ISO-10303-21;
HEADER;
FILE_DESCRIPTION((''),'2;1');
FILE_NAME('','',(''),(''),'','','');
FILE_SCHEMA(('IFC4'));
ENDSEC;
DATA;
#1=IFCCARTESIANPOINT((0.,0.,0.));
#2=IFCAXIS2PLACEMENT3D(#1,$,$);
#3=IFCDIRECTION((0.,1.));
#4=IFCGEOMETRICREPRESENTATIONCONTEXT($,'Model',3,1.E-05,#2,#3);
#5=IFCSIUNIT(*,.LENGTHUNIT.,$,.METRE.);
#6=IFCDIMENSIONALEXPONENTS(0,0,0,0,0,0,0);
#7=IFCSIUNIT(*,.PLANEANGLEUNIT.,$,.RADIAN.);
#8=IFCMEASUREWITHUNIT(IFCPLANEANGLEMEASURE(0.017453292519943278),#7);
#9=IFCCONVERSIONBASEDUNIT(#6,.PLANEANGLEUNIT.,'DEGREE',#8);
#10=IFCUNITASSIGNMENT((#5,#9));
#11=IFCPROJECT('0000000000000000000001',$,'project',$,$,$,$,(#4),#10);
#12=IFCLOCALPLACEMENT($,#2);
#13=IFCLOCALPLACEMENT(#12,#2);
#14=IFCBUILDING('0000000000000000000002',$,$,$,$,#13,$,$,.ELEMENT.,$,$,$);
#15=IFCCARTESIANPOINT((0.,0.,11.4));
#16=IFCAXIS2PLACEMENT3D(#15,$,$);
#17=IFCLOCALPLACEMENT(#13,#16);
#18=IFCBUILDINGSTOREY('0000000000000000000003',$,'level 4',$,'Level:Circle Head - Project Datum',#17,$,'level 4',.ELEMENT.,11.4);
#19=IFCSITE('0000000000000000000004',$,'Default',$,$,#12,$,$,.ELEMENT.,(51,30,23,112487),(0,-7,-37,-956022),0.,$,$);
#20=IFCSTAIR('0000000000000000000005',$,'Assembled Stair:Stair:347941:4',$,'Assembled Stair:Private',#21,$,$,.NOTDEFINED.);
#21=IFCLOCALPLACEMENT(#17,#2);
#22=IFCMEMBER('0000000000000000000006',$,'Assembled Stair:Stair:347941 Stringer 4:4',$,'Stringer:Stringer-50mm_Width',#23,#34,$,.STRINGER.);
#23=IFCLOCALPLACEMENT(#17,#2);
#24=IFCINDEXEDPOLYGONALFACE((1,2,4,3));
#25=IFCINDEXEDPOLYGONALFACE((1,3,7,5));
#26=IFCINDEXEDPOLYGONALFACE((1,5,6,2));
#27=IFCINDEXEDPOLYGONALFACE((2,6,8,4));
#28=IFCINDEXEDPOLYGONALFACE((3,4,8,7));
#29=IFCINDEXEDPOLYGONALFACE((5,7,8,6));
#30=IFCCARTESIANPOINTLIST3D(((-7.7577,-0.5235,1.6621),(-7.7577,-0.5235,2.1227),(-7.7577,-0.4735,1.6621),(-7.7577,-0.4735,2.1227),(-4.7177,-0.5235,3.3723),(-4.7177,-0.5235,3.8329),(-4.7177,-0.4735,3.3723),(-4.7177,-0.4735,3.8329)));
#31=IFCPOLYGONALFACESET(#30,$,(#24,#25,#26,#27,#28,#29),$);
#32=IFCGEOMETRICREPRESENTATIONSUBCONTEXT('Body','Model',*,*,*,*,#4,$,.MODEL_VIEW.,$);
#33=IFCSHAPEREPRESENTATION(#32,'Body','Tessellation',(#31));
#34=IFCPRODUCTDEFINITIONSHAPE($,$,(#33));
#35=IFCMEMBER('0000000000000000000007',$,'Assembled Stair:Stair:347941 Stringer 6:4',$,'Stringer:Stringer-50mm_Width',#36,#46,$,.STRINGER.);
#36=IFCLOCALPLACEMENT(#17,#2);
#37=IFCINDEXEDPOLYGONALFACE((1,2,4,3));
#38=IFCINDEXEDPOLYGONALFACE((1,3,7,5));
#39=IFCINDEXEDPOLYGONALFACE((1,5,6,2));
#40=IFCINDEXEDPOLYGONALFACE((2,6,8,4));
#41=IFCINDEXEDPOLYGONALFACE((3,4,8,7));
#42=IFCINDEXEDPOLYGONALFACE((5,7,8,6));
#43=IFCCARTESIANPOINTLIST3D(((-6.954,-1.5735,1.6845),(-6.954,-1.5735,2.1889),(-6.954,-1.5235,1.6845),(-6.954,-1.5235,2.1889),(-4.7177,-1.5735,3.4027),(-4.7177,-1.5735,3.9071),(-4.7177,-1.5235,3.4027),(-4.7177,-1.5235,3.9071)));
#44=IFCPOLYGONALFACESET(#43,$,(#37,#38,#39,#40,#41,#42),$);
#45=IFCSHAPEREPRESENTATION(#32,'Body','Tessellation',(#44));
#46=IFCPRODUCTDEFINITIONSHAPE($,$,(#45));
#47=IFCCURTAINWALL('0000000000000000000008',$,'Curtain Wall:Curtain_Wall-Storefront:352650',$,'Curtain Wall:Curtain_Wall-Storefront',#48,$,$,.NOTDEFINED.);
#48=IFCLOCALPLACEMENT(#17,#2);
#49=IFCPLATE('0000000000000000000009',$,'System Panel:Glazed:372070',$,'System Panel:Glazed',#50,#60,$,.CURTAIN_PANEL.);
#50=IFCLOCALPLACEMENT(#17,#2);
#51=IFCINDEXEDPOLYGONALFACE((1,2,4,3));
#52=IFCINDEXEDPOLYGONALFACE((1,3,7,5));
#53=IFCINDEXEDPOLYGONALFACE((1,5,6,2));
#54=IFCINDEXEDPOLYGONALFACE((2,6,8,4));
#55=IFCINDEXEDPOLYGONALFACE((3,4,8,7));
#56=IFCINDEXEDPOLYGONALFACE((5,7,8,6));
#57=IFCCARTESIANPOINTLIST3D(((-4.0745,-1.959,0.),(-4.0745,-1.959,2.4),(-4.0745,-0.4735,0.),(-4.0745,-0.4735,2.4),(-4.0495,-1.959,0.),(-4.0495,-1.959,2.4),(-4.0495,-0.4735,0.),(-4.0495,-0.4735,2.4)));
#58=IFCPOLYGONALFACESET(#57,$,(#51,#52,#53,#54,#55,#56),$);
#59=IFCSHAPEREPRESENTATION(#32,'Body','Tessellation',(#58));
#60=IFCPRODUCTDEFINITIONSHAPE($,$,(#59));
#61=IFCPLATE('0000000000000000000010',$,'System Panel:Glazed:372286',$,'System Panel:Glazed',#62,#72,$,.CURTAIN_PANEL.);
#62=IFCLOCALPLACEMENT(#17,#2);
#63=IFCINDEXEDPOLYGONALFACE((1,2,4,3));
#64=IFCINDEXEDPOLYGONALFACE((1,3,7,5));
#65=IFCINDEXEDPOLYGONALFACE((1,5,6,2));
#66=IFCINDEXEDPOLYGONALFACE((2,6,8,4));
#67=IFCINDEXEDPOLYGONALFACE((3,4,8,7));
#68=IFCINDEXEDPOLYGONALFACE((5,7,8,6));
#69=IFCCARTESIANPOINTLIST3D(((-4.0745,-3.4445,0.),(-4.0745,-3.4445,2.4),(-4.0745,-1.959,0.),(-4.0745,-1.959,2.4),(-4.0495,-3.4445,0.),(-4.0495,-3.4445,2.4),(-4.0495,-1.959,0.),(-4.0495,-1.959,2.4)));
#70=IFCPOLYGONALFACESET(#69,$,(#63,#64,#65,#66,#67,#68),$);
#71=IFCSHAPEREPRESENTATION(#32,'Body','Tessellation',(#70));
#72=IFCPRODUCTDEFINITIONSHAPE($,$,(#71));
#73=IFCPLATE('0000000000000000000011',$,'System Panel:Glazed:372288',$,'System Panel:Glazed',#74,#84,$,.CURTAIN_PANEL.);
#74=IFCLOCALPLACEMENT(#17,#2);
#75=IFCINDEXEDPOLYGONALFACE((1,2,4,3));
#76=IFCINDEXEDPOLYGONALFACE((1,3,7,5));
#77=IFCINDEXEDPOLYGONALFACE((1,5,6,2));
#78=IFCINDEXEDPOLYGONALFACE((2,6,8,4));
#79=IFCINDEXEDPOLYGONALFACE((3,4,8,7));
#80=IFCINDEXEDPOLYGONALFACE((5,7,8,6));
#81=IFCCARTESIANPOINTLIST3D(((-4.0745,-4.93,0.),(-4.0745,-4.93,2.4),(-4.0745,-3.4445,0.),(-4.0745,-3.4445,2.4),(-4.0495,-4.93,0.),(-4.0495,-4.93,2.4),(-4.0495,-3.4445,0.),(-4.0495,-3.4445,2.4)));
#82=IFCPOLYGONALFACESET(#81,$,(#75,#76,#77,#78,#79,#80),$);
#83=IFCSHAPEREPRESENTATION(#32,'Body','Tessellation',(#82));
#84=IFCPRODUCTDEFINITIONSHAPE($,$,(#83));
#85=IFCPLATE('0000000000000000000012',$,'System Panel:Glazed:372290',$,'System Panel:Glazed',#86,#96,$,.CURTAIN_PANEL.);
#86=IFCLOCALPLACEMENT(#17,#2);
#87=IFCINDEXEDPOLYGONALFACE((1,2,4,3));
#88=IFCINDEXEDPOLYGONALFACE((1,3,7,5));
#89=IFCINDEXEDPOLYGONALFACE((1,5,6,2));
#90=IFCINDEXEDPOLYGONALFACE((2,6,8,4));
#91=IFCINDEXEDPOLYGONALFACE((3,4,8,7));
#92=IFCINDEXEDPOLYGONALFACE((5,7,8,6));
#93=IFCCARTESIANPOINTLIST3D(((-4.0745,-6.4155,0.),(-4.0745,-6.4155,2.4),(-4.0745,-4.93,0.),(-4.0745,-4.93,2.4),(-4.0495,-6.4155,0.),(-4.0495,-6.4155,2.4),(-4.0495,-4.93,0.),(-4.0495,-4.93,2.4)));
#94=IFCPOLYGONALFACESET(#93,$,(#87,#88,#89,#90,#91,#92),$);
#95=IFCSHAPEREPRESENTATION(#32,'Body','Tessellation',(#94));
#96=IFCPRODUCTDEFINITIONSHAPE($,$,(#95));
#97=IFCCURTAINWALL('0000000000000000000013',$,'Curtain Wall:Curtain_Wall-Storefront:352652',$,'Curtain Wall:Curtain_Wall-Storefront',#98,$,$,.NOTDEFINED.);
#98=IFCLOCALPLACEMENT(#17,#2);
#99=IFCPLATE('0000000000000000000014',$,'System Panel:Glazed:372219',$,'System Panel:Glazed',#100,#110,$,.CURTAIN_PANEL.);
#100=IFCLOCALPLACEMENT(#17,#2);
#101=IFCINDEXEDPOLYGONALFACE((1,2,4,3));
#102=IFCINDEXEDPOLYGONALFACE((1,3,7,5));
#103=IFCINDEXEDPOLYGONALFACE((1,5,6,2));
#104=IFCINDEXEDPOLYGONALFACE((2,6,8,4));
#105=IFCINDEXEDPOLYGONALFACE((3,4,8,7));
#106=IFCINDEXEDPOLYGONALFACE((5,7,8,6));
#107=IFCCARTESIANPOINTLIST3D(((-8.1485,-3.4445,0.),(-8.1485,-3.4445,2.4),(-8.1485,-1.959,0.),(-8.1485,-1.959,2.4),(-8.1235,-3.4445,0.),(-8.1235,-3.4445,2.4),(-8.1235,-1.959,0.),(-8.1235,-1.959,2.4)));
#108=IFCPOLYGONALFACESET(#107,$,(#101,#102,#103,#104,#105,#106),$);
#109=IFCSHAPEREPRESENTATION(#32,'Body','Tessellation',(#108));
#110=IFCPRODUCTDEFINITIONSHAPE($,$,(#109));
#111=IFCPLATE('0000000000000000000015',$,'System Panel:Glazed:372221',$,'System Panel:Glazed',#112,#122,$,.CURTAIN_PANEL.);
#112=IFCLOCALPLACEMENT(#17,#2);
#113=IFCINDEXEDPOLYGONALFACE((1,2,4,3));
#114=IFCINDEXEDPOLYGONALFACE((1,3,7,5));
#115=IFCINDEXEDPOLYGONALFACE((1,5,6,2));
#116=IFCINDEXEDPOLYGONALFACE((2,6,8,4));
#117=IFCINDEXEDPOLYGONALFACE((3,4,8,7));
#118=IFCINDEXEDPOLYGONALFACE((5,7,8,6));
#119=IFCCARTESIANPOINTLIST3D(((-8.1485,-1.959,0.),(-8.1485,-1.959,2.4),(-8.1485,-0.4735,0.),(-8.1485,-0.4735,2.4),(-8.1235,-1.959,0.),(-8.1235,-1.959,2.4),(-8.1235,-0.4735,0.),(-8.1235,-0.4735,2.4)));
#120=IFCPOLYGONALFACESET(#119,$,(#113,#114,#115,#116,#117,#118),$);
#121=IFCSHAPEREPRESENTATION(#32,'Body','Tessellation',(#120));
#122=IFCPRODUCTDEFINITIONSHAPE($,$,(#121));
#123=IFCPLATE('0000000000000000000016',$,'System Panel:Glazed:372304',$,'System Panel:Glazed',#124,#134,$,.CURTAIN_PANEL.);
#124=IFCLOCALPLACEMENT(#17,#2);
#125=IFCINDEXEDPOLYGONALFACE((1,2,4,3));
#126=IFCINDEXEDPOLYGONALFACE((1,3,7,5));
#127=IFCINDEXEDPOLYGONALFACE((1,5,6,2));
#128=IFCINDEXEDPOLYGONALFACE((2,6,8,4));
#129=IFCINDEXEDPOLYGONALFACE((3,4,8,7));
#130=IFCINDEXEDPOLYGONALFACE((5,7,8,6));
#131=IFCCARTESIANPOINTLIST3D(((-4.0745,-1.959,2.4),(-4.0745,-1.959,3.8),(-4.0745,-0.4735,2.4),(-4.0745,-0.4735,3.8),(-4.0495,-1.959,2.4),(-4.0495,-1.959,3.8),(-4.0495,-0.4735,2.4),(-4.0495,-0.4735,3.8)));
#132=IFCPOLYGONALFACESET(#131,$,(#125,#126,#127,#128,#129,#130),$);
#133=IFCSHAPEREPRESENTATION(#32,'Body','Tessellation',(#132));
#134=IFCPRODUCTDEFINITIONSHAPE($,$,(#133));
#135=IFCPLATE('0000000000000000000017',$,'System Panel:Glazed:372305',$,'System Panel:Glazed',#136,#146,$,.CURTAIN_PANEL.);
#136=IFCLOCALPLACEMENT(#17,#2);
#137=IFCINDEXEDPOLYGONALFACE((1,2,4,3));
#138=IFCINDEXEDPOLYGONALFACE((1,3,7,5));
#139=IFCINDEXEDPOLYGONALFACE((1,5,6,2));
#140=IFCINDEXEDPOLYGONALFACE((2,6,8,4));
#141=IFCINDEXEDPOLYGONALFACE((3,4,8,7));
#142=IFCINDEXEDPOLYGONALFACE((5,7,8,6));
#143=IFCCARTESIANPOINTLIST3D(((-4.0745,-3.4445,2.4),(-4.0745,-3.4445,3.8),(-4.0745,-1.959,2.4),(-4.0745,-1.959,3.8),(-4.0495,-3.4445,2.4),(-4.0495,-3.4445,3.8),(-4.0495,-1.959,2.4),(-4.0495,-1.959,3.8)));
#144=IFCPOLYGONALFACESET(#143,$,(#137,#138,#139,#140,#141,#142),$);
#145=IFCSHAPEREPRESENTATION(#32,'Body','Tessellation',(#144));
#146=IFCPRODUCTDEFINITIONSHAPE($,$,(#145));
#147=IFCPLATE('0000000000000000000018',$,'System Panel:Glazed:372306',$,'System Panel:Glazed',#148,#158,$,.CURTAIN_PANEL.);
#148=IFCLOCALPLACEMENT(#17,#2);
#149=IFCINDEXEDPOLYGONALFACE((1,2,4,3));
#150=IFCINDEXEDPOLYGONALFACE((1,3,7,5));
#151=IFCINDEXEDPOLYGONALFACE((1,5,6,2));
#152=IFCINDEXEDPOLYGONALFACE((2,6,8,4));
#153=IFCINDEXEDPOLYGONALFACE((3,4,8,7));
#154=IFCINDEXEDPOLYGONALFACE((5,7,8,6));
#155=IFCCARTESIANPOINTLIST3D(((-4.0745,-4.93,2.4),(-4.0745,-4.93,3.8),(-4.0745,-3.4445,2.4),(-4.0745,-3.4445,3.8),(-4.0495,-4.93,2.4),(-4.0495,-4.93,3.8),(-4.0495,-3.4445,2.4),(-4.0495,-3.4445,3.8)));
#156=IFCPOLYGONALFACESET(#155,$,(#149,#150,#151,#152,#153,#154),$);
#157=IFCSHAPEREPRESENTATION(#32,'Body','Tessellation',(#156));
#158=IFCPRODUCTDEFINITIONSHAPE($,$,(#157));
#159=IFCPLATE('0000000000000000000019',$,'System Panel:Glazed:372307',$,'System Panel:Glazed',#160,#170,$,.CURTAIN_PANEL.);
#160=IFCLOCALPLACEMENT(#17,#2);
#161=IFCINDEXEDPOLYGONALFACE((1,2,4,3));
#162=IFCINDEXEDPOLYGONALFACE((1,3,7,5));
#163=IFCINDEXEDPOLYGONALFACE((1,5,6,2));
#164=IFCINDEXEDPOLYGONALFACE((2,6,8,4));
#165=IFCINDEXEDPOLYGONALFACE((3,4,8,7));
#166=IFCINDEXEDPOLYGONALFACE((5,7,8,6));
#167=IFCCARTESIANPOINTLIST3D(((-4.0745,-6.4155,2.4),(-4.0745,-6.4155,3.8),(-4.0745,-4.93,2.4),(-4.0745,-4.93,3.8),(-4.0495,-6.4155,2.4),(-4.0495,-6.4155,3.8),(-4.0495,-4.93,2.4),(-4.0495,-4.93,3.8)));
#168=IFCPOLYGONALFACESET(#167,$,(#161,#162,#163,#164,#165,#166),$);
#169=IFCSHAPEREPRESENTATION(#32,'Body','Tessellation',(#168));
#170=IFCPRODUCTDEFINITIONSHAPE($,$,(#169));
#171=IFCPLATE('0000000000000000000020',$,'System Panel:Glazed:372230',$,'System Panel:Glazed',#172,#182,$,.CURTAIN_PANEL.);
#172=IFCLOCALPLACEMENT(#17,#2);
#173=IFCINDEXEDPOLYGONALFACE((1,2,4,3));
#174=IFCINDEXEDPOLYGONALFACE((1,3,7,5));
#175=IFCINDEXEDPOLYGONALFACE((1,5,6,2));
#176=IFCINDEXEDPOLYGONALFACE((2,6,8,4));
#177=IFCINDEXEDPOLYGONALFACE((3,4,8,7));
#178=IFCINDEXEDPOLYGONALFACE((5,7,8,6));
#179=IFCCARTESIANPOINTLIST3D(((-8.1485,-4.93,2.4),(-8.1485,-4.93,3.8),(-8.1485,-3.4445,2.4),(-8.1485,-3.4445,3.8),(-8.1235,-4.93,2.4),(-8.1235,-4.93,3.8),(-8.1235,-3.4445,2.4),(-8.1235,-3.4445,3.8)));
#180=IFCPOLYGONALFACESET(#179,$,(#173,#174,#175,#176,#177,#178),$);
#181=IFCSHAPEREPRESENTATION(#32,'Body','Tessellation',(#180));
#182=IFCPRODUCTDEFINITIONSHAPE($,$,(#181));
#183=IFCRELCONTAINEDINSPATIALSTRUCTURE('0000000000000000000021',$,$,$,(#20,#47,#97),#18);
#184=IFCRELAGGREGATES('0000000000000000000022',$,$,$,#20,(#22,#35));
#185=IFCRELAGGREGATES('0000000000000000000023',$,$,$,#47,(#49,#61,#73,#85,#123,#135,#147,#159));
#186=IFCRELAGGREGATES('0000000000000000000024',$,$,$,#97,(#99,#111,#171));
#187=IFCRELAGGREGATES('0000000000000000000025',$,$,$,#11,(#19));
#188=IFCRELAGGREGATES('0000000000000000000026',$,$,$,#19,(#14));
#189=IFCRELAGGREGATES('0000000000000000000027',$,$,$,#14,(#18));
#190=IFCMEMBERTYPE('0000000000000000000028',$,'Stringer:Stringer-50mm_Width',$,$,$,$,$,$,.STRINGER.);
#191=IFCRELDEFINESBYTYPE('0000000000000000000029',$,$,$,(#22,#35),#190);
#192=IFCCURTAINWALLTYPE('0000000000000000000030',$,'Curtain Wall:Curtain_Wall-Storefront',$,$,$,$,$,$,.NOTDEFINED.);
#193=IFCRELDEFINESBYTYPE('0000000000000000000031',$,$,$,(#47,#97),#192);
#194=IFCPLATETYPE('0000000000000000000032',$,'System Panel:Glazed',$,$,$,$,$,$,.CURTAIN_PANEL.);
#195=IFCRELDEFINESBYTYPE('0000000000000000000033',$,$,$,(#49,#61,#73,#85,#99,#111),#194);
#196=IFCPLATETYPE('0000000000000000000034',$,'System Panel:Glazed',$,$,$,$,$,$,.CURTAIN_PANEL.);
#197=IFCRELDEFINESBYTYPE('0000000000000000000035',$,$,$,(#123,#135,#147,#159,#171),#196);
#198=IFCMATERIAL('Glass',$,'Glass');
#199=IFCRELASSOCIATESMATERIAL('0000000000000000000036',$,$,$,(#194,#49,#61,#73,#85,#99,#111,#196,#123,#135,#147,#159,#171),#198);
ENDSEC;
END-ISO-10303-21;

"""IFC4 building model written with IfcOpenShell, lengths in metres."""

from ifc_helpers import new_model, entity, si_unit, converted_unit, direction, frame, origin, origin_2d_with_axis, place, context, subcontext, project, spatial, polyline, rectangle, outline, extrude, source, transform, mapped, material, type_object, type_shapes, element, aggregate, save


model = new_model("IFC4")

# Units and contexts
model_context = context("Model", 3, precision=1e-05, world=origin(), true_north=direction((0.0, 1.0)))
body_context = subcontext(model_context, "Body", "Model", "MODEL_VIEW")
ifc_project = project(units=[si_unit("LENGTHUNIT", "METRE"), converted_unit("PLANEANGLEUNIT", "DEGREE", entity("IfcPlaneAngleMeasure", 0.017453292519943278), si_unit("PLANEANGLEUNIT", "RADIAN"), dimensions=[0, 0, 0, 0, 0, 0, 0])], contexts=[model_context])

# Site, building, storey
site_placement = place(None, origin())
site = spatial("IfcSite", under=ifc_project, at=site_placement, Name="Default", CompositionType="ELEMENT", RefLatitude=(51, 30, 23, 112487), RefLongitude=(0, -7, -37, -956022), RefElevation=0.0)
building_placement = place(site_placement, origin())
building = spatial("IfcBuilding", under=site, at=building_placement, CompositionType="ELEMENT")
storey_placement = place(building_placement, frame((0.0, 0.0, 11.4)))
storey = spatial("IfcBuildingStorey", under=building, at=storey_placement, Name="level 4", ObjectType="Level:Circle Head - Project Datum", LongName="level 4", CompositionType="ELEMENT", Elevation=11.4)

# Stair, members
stair_placement = place(storey_placement, origin())
stair = element("IfcStair", 1, at=stair_placement, inside=storey, Name="Assembled Stair:Stair:347941:4", ObjectType="Assembled Stair:Private", PredefinedType="NOTDEFINED")
member_type = type_object("IfcMemberType", Name="Stringer:Stringer-50mm_Width", PredefinedType="STRINGER")
member_1_placement = place(stair_placement, frame((-7.7577, -0.5235, 1.6621)))
member_1 = element("IfcMember", 2, at=member_1_placement, type_object=member_type, Name="Assembled Stair:Stair:347941 Stringer 4:4", ObjectType="Stringer:Stringer-50mm_Width", PredefinedType="STRINGER", context=body_context, shape_type="SweptSolid", body=[
    extrude(outline(polyline([(-1.6311, -0.2007), (1.857, -0.2007), (1.6311, 0.2007), (-1.857, 0.2007), (-1.6311, -0.2007)])), frame((1.52, 0.0, 1.0854), z_axis=(0.0, 1.0, 0.0), x_axis=(0.871553, 0.0, 0.490302)), (0.0, 0.0, 1.0), 0.05),
])
member_2_placement = place(stair_placement, frame((-6.954, -1.5735, 1.6845)))
member_2 = element("IfcMember", 3, at=member_2_placement, type_object=member_type, Name="Assembled Stair:Stair:347941 Stringer 6:4", ObjectType="Stringer:Stringer-50mm_Width", PredefinedType="STRINGER", context=body_context, shape_type="SweptSolid", body=[
    extrude(outline(polyline([(-1.2564, -0.2), (1.5637, -0.2), (1.2564, 0.2), (-1.5637, 0.2), (-1.2564, -0.2)])), frame((1.1182, 0.0, 1.1113), z_axis=(0.0, 1.0, 0.0), x_axis=(0.792984, 0.0, 0.609242)), (0.0, 0.0, 1.0), 0.05),
])
aggregate(stair, [member_1, member_2])

# Curtain walls, plates
curtain_wall_type = type_object("IfcCurtainWallType", Name="Curtain Wall:Curtain_Wall-Storefront", PredefinedType="NOTDEFINED")
curtain_wall_1_placement = place(storey_placement, frame((0.0, 0.0, -11.4)))
curtain_wall_1 = element("IfcCurtainWall", 4, at=curtain_wall_1_placement, inside=storey, type_object=curtain_wall_type, Name="Curtain Wall:Curtain_Wall-Storefront:352650", ObjectType="Curtain Wall:Curtain_Wall-Storefront", PredefinedType="NOTDEFINED")
ifc_material_1 = material(Name="Glass", Category="Glass")
plate_type_1 = type_object("IfcPlateType", Name="System Panel:Glazed", PredefinedType="CURTAIN_PANEL", material=ifc_material_1)
shared_shape_1 = source(origin(), body_context, "Body", "SweptSolid", [
    extrude(rectangle(XDim=0.025, YDim=1.4855, at=origin_2d_with_axis()), frame((0.7428, 0.0125, 0.0), z_axis=(0.0, 0.0, 1.0), x_axis=(0.0, 1.0, 0.0)), (0.0, 0.0, 1.0), 2.4),
])
type_shapes(plate_type_1, [shared_shape_1])
plate_1_placement = place(curtain_wall_1_placement, frame((-4.0745, -0.4735, 11.4), z_axis=(0.0, 0.0, 1.0), x_axis=(0.0, -1.0, 0.0)))
plate_1 = element("IfcPlate", 5, at=plate_1_placement, type_object=plate_type_1, material=ifc_material_1, Name="System Panel:Glazed:372070", ObjectType="System Panel:Glazed", PredefinedType="CURTAIN_PANEL", context=body_context, shape_type="MappedRepresentation", body=[
    mapped(shared_shape_1, transform((0.0, 0.0, 0.0), scale=1.0)),
])
plate_2_placement = place(curtain_wall_1_placement, frame((-4.0745, -1.959, 11.4), z_axis=(0.0, 0.0, 1.0), x_axis=(0.0, -1.0, 0.0)))
plate_2 = element("IfcPlate", 6, at=plate_2_placement, type_object=plate_type_1, material=ifc_material_1, Name="System Panel:Glazed:372286", ObjectType="System Panel:Glazed", PredefinedType="CURTAIN_PANEL", context=body_context, shape_type="MappedRepresentation", body=[
    mapped(shared_shape_1, transform((0.0, 0.0, 0.0), scale=1.0)),
])
plate_3_placement = place(curtain_wall_1_placement, frame((-4.0745, -3.4445, 11.4), z_axis=(0.0, 0.0, 1.0), x_axis=(0.0, -1.0, 0.0)))
plate_3 = element("IfcPlate", 7, at=plate_3_placement, type_object=plate_type_1, material=ifc_material_1, Name="System Panel:Glazed:372288", ObjectType="System Panel:Glazed", PredefinedType="CURTAIN_PANEL", context=body_context, shape_type="MappedRepresentation", body=[
    mapped(shared_shape_1, transform((0.0, 0.0, 0.0), scale=1.0)),
])
plate_4_placement = place(curtain_wall_1_placement, frame((-4.0745, -4.93, 11.4), z_axis=(0.0, 0.0, 1.0), x_axis=(0.0, -1.0, 0.0)))
plate_4 = element("IfcPlate", 8, at=plate_4_placement, type_object=plate_type_1, material=ifc_material_1, Name="System Panel:Glazed:372290", ObjectType="System Panel:Glazed", PredefinedType="CURTAIN_PANEL", context=body_context, shape_type="MappedRepresentation", body=[
    mapped(shared_shape_1, transform((0.0, 0.0, 0.0), scale=1.0)),
])
curtain_wall_2_placement = place(storey_placement, frame((0.0, 0.0, -11.4)))
curtain_wall_2 = element("IfcCurtainWall", 9, at=curtain_wall_2_placement, inside=storey, type_object=curtain_wall_type, Name="Curtain Wall:Curtain_Wall-Storefront:352652", ObjectType="Curtain Wall:Curtain_Wall-Storefront", PredefinedType="NOTDEFINED")
plate_5_placement = place(curtain_wall_2_placement, frame((-8.1235, -3.4445, 11.4), z_axis=(0.0, 0.0, 1.0), x_axis=(0.0, 1.0, 0.0)))
plate_5 = element("IfcPlate", 10, at=plate_5_placement, type_object=plate_type_1, material=ifc_material_1, Name="System Panel:Glazed:372219", ObjectType="System Panel:Glazed", PredefinedType="CURTAIN_PANEL", context=body_context, shape_type="MappedRepresentation", body=[
    mapped(shared_shape_1, transform((0.0, 0.0, 0.0), scale=1.0)),
])
plate_6_placement = place(curtain_wall_2_placement, frame((-8.1235, -1.959, 11.4), z_axis=(0.0, 0.0, 1.0), x_axis=(0.0, 1.0, 0.0)))
plate_6 = element("IfcPlate", 11, at=plate_6_placement, type_object=plate_type_1, material=ifc_material_1, Name="System Panel:Glazed:372221", ObjectType="System Panel:Glazed", PredefinedType="CURTAIN_PANEL", context=body_context, shape_type="MappedRepresentation", body=[
    mapped(shared_shape_1, transform((0.0, 0.0, 0.0), scale=1.0)),
])

# Plates
plate_type_2 = type_object("IfcPlateType", Name="System Panel:Glazed", PredefinedType="CURTAIN_PANEL", material=ifc_material_1)
shared_shape_2 = source(origin(), body_context, "Body", "SweptSolid", [
    extrude(rectangle(XDim=0.025, YDim=1.4855, at=origin_2d_with_axis()), frame((0.7428, 0.0125, 0.0), z_axis=(0.0, 0.0, 1.0), x_axis=(0.0, 1.0, 0.0)), (0.0, 0.0, 1.0), 1.4),
])
type_shapes(plate_type_2, [shared_shape_2])
plate_7_placement = place(curtain_wall_1_placement, frame((-4.0745, -0.4735, 13.8), z_axis=(0.0, 0.0, 1.0), x_axis=(0.0, -1.0, 0.0)))
plate_7 = element("IfcPlate", 12, at=plate_7_placement, type_object=plate_type_2, material=ifc_material_1, Name="System Panel:Glazed:372304", ObjectType="System Panel:Glazed", PredefinedType="CURTAIN_PANEL", context=body_context, shape_type="MappedRepresentation", body=[
    mapped(shared_shape_2, transform((0.0, 0.0, 0.0), scale=1.0)),
])
plate_8_placement = place(curtain_wall_1_placement, frame((-4.0745, -1.959, 13.8), z_axis=(0.0, 0.0, 1.0), x_axis=(0.0, -1.0, 0.0)))
plate_8 = element("IfcPlate", 13, at=plate_8_placement, type_object=plate_type_2, material=ifc_material_1, Name="System Panel:Glazed:372305", ObjectType="System Panel:Glazed", PredefinedType="CURTAIN_PANEL", context=body_context, shape_type="MappedRepresentation", body=[
    mapped(shared_shape_2, transform((0.0, 0.0, 0.0), scale=1.0)),
])
plate_9_placement = place(curtain_wall_1_placement, frame((-4.0745, -3.4445, 13.8), z_axis=(0.0, 0.0, 1.0), x_axis=(0.0, -1.0, 0.0)))
plate_9 = element("IfcPlate", 14, at=plate_9_placement, type_object=plate_type_2, material=ifc_material_1, Name="System Panel:Glazed:372306", ObjectType="System Panel:Glazed", PredefinedType="CURTAIN_PANEL", context=body_context, shape_type="MappedRepresentation", body=[
    mapped(shared_shape_2, transform((0.0, 0.0, 0.0), scale=1.0)),
])
plate_10_placement = place(curtain_wall_1_placement, frame((-4.0745, -4.93, 13.8), z_axis=(0.0, 0.0, 1.0), x_axis=(0.0, -1.0, 0.0)))
plate_10 = element("IfcPlate", 15, at=plate_10_placement, type_object=plate_type_2, material=ifc_material_1, Name="System Panel:Glazed:372307", ObjectType="System Panel:Glazed", PredefinedType="CURTAIN_PANEL", context=body_context, shape_type="MappedRepresentation", body=[
    mapped(shared_shape_2, transform((0.0, 0.0, 0.0), scale=1.0)),
])
aggregate(curtain_wall_1, [plate_1, plate_2, plate_3, plate_4, plate_7, plate_8, plate_9, plate_10])
plate_11_placement = place(curtain_wall_2_placement, frame((-8.1235, -4.93, 13.8), z_axis=(0.0, 0.0, 1.0), x_axis=(0.0, 1.0, 0.0)))
plate_11 = element("IfcPlate", 16, at=plate_11_placement, type_object=plate_type_2, material=ifc_material_1, Name="System Panel:Glazed:372230", ObjectType="System Panel:Glazed", PredefinedType="CURTAIN_PANEL", context=body_context, shape_type="MappedRepresentation", body=[
    mapped(shared_shape_2, transform((0.0, 0.0, 0.0), scale=1.0)),
])
aggregate(curtain_wall_2, [plate_5, plate_6, plate_11])

save(model, "model.ifc")
